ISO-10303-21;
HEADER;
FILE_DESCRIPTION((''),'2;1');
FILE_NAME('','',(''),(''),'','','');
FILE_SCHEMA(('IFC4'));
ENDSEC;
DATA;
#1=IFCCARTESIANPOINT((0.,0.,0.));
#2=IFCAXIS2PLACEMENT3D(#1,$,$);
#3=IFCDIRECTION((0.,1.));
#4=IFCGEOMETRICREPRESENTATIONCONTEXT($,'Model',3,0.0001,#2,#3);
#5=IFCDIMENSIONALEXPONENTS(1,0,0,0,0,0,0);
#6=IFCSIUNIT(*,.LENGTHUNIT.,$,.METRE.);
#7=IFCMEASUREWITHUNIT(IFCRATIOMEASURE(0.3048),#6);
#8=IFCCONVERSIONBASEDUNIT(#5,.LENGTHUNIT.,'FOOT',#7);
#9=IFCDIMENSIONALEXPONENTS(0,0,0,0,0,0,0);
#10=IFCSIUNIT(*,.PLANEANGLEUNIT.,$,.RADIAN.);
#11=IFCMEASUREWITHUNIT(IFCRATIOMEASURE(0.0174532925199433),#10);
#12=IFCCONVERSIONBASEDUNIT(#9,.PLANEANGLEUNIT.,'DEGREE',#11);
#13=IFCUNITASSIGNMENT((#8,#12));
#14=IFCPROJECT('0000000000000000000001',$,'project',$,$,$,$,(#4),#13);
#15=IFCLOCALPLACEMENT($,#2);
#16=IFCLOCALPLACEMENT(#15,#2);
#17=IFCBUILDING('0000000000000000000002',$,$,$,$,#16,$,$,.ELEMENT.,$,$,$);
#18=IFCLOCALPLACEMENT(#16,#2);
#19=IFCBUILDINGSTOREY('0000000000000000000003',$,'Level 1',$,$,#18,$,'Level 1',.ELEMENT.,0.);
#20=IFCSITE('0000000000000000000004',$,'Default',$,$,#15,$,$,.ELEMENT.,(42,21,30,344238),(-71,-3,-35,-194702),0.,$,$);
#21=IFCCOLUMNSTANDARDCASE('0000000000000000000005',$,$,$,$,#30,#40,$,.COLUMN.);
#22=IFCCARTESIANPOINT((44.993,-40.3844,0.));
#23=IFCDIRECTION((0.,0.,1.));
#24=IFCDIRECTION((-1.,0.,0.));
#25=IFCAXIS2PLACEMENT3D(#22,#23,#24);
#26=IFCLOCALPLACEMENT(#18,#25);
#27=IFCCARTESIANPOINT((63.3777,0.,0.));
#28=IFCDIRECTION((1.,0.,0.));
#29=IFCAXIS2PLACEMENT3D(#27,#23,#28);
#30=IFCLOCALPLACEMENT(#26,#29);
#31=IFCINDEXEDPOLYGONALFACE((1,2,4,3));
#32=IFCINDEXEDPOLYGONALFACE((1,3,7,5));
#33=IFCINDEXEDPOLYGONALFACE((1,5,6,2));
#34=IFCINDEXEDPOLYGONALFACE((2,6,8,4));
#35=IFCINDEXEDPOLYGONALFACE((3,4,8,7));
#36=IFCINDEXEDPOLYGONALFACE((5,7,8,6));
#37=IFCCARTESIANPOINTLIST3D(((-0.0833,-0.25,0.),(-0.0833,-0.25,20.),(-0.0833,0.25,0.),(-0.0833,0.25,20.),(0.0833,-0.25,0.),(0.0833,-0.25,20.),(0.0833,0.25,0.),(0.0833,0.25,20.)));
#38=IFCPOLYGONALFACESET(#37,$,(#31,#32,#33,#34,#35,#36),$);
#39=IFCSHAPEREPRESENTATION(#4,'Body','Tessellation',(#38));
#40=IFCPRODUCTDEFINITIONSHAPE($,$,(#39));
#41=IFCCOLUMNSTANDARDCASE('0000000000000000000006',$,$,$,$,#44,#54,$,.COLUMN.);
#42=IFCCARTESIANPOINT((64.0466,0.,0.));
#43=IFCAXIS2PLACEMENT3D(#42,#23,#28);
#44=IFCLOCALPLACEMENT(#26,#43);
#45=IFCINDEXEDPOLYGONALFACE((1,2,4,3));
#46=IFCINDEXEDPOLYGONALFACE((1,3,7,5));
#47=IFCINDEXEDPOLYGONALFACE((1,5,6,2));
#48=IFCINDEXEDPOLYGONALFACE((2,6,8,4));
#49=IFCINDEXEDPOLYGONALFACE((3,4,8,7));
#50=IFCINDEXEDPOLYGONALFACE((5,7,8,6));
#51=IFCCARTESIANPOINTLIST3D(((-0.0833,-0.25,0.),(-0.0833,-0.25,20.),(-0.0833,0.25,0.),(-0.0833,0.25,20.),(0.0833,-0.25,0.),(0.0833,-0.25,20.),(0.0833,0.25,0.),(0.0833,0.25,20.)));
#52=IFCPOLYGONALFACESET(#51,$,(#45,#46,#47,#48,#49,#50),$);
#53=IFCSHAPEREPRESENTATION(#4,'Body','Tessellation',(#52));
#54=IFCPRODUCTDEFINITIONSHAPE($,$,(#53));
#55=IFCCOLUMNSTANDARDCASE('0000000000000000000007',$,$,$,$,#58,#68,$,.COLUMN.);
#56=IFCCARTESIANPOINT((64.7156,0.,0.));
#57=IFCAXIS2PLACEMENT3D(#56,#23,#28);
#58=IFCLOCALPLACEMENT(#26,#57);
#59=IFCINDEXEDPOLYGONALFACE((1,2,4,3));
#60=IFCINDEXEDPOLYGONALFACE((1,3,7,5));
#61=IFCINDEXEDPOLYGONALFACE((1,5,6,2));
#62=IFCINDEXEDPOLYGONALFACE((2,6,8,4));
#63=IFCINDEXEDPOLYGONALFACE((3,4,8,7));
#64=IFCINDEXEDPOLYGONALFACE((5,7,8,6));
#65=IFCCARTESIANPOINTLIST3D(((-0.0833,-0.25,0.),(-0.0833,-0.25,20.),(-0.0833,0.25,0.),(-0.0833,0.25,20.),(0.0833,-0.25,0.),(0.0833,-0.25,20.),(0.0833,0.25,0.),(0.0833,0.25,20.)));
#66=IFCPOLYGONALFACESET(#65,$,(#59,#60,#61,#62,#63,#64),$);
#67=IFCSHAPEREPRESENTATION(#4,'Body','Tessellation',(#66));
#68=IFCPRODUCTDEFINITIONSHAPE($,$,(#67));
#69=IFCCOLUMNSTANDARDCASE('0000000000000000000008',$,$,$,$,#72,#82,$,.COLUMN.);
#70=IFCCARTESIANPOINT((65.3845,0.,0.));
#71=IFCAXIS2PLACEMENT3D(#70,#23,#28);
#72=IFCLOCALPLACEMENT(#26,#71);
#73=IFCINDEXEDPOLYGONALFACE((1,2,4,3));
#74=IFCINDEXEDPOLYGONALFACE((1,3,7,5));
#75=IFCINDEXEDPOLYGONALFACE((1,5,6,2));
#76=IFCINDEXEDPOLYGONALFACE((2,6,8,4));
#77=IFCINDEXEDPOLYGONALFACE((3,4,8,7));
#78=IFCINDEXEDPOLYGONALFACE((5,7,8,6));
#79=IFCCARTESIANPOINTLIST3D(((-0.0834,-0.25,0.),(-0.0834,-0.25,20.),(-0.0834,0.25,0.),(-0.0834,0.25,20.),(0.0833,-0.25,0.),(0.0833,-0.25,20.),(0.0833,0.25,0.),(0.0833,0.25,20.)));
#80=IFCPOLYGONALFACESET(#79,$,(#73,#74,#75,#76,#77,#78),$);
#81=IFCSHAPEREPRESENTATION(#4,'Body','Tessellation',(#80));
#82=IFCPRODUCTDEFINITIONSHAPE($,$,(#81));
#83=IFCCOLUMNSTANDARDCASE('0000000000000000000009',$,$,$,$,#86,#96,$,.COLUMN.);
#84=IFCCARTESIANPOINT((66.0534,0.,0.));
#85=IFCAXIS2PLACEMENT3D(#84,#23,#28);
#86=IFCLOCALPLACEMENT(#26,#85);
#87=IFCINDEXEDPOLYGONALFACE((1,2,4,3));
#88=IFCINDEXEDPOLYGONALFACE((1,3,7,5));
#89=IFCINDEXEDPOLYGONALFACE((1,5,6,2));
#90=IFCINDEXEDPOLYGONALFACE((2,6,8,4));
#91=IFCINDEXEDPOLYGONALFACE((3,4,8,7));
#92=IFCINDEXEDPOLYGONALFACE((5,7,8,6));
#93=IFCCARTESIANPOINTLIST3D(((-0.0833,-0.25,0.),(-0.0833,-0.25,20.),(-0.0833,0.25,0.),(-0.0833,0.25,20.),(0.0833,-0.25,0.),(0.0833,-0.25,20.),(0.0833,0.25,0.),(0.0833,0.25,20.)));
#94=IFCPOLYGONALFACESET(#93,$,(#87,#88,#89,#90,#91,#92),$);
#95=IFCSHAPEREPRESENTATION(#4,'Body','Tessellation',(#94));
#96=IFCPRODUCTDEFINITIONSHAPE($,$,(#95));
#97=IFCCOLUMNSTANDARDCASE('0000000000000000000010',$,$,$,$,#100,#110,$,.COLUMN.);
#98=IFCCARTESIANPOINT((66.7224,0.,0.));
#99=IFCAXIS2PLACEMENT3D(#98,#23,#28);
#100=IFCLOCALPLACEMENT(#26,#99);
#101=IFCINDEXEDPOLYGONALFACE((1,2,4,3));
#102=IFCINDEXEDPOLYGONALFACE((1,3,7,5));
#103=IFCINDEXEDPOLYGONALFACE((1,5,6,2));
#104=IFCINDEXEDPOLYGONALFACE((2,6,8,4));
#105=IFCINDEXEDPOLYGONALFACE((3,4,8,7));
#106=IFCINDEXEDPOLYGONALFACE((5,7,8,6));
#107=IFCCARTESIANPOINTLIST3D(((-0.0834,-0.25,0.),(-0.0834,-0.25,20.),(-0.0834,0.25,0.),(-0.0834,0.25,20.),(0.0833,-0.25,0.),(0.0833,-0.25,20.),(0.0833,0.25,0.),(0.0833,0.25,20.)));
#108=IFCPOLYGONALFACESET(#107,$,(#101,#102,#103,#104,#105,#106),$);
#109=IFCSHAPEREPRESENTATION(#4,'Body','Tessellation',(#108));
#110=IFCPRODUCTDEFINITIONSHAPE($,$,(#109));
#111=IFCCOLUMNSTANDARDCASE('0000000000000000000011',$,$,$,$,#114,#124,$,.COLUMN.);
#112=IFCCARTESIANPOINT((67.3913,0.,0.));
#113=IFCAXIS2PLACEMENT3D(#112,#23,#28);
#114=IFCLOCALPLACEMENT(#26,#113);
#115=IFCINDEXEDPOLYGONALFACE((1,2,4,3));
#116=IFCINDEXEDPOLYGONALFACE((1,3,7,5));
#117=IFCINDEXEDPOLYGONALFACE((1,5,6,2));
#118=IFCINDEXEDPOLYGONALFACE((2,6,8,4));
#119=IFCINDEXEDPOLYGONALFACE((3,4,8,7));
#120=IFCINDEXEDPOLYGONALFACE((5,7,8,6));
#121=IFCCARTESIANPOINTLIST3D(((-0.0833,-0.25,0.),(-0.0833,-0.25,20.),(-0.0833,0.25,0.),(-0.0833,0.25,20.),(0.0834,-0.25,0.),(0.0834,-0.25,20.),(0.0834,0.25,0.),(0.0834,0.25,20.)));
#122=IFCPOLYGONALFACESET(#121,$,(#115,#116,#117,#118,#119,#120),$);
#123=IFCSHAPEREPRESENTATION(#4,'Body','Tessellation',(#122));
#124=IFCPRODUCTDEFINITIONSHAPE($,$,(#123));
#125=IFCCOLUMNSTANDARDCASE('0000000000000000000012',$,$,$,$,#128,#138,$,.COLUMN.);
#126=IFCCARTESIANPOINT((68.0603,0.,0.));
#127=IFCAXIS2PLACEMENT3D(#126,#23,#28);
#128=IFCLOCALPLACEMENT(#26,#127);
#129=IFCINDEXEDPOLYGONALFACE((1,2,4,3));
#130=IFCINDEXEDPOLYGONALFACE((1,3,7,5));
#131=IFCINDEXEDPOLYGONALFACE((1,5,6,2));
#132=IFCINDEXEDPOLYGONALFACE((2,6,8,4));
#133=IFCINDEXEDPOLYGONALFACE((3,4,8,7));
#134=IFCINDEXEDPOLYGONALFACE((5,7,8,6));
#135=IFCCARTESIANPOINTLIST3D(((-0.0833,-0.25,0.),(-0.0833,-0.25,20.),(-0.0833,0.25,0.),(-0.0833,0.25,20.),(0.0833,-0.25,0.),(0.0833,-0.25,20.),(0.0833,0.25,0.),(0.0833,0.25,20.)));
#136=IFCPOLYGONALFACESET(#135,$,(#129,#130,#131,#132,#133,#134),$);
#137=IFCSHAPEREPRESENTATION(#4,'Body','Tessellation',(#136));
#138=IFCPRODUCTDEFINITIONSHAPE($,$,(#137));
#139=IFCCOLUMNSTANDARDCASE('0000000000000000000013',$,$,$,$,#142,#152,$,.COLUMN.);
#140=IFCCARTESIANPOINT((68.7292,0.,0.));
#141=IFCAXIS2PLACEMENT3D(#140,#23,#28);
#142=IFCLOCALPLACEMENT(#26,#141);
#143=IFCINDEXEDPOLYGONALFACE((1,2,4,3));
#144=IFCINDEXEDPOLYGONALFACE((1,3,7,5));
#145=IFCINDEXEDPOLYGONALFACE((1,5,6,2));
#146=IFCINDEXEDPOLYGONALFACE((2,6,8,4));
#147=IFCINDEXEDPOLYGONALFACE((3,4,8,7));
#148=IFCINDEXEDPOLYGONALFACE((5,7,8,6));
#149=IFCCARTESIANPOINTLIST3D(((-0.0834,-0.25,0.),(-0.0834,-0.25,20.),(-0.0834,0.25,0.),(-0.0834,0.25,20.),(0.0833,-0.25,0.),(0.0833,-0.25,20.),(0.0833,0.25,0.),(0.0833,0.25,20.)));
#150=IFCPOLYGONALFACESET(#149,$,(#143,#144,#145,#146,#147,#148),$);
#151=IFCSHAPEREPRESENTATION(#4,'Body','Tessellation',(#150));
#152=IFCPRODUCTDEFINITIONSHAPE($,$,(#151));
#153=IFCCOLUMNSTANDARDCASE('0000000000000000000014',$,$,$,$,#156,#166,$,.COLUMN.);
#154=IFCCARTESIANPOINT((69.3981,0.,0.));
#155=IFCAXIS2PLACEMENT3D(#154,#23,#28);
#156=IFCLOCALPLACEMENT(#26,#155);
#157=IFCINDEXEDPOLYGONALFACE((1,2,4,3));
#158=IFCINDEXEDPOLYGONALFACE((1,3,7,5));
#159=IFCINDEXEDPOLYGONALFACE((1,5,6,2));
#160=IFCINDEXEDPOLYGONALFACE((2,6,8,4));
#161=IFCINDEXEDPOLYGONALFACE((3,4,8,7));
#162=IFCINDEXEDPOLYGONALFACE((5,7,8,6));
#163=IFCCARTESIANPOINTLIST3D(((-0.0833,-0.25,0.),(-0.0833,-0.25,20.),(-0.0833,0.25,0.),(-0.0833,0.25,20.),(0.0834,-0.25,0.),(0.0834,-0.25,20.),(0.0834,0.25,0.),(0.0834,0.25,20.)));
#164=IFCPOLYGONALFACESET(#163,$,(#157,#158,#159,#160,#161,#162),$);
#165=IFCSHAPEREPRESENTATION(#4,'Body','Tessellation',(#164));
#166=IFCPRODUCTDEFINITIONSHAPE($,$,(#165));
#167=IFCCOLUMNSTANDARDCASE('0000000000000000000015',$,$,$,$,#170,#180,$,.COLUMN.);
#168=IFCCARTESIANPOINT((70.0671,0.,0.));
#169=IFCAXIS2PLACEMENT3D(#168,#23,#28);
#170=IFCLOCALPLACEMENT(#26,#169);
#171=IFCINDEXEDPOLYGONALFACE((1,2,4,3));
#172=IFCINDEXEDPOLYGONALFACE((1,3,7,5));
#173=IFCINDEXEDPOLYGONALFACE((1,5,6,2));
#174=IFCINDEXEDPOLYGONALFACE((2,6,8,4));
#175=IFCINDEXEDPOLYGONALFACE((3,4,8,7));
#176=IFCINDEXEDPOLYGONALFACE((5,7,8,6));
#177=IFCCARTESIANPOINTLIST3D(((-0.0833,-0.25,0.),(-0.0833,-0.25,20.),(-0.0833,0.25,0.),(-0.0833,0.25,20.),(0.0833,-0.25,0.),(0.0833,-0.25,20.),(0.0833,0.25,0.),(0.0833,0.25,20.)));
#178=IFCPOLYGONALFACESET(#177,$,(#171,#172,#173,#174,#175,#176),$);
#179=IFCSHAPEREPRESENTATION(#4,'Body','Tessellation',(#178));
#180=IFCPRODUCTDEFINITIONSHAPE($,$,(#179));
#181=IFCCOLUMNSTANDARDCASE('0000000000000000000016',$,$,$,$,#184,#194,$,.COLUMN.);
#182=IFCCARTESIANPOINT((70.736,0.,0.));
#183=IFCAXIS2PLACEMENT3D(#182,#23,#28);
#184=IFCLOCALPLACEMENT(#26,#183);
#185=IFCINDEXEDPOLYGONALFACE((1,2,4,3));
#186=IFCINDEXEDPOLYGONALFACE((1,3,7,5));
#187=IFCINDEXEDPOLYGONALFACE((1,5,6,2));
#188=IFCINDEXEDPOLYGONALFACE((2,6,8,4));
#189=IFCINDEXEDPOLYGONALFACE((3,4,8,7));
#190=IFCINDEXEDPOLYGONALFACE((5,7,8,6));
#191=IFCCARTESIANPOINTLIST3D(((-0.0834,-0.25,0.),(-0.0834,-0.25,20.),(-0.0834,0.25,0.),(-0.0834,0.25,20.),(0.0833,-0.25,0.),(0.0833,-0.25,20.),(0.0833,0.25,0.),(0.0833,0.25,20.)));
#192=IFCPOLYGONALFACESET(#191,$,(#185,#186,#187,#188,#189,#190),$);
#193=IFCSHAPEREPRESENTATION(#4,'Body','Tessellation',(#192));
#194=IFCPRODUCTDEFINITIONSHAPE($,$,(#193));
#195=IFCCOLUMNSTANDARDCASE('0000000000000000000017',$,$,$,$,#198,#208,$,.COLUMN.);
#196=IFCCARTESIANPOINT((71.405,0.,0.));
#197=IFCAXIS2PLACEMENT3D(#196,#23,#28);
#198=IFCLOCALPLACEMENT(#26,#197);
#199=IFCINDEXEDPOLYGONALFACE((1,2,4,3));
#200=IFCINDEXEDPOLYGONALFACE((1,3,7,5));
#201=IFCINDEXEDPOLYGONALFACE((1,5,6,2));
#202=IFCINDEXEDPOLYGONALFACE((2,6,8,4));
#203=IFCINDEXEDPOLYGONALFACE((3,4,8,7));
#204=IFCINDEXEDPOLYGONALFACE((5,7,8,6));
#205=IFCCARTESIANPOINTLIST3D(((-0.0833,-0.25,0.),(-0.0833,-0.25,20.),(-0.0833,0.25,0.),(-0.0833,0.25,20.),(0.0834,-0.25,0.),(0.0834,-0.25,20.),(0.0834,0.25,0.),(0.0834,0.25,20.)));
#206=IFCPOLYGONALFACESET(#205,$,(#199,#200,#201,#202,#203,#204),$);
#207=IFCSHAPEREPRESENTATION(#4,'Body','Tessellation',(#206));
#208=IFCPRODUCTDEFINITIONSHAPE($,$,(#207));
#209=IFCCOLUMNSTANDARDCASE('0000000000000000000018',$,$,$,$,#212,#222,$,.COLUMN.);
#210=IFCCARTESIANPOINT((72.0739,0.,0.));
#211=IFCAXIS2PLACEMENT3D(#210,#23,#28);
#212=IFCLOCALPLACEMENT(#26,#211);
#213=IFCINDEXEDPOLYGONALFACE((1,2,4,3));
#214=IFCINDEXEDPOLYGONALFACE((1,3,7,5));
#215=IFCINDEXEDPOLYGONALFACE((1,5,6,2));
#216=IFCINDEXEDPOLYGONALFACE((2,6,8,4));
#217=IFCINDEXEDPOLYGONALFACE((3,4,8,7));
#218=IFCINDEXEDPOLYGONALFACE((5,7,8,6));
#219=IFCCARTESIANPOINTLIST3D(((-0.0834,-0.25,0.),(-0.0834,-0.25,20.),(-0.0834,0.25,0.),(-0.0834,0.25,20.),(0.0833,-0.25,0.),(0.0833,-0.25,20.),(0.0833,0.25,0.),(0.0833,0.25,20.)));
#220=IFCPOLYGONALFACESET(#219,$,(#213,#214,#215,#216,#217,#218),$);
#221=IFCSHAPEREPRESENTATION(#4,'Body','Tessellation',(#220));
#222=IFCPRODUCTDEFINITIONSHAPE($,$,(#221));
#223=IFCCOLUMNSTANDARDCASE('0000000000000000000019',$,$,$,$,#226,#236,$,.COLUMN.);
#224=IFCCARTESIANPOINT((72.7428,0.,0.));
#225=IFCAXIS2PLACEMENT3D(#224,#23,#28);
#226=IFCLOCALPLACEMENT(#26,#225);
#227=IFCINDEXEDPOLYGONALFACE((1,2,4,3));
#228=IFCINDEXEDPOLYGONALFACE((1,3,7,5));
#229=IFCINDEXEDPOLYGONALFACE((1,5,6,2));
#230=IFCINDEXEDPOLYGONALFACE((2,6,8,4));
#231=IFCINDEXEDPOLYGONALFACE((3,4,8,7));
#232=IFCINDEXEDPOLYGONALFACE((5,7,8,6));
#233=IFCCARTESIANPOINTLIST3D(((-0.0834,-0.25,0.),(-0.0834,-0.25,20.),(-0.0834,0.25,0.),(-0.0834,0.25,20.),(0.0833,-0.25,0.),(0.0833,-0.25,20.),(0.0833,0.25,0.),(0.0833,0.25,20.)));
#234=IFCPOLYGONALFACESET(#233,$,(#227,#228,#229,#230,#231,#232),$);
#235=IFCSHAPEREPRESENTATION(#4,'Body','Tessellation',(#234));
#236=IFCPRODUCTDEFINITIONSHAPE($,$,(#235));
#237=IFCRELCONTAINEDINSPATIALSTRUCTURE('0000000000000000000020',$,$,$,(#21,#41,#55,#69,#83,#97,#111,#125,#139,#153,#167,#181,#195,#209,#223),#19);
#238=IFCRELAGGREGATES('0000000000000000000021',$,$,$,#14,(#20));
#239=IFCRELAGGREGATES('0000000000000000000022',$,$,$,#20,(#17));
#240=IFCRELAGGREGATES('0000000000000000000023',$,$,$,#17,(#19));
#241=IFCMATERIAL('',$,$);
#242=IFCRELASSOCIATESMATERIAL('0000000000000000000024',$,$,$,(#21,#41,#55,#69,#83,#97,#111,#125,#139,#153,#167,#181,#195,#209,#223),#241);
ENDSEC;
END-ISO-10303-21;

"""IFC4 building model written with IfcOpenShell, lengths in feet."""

from ifc_helpers import new_model, entity, si_unit, converted_unit, direction, frame, origin, place, context, project, spatial, rectangle, extrude, material, element, save


model = new_model("IFC4")

# Units and contexts
model_context = context("Model", 3, precision=0.0001, world=origin(), true_north=direction((0.0, 1.0)))
ifc_project = project(units=[converted_unit("LENGTHUNIT", "FOOT", entity("IfcRatioMeasure", 0.3048), si_unit("LENGTHUNIT", "METRE"), dimensions=[1, 0, 0, 0, 0, 0, 0]), converted_unit("PLANEANGLEUNIT", "DEGREE", entity("IfcRatioMeasure", 0.0174532925199433), si_unit("PLANEANGLEUNIT", "RADIAN"), dimensions=[0, 0, 0, 0, 0, 0, 0])], contexts=[model_context])

# Site, building, storey
site_placement = place(None, origin())
site = spatial("IfcSite", under=ifc_project, at=site_placement, Name="Default", CompositionType="ELEMENT", RefLatitude=(42, 21, 30, 344238), RefLongitude=(-71, -3, -35, -194702), RefElevation=0.0)
building_placement = place(site_placement, origin())
building = spatial("IfcBuilding", under=site, at=building_placement, CompositionType="ELEMENT")
storey_placement = place(building_placement, origin())
storey = spatial("IfcBuildingStorey", under=building, at=storey_placement, Name="Level 1", LongName="Level 1", CompositionType="ELEMENT", Elevation=0.0)

# Columns
ifc_material_1 = material(Name="")
placement = place(storey_placement, frame((44.993, -40.3844, 0.0), z_axis=(0.0, 0.0, 1.0), x_axis=(-1.0, 0.0, 0.0)))
for number, where, z_axis, x_axis in (
    (1, (63.3777, 0.0, 0.0), (0.0, 0.0, 1.0), (1.0, 0.0, 0.0)),
    (2, (64.0466, 0.0, 0.0), (0.0, 0.0, 1.0), (1.0, 0.0, 0.0)),
    (3, (64.7156, 0.0, 0.0), (0.0, 0.0, 1.0), (1.0, 0.0, 0.0)),
    (4, (65.3845, 0.0, 0.0), (0.0, 0.0, 1.0), (1.0, 0.0, 0.0)),
    (5, (66.0534, 0.0, 0.0), (0.0, 0.0, 1.0), (1.0, 0.0, 0.0)),
    (6, (66.7224, 0.0, 0.0), (0.0, 0.0, 1.0), (1.0, 0.0, 0.0)),
    (7, (67.3913, 0.0, 0.0), (0.0, 0.0, 1.0), (1.0, 0.0, 0.0)),
    (8, (68.0603, 0.0, 0.0), (0.0, 0.0, 1.0), (1.0, 0.0, 0.0)),
    (9, (68.7292, 0.0, 0.0), (0.0, 0.0, 1.0), (1.0, 0.0, 0.0)),
    (10, (69.3981, 0.0, 0.0), (0.0, 0.0, 1.0), (1.0, 0.0, 0.0)),
    (11, (70.0671, 0.0, 0.0), (0.0, 0.0, 1.0), (1.0, 0.0, 0.0)),
    (12, (70.736, 0.0, 0.0), (0.0, 0.0, 1.0), (1.0, 0.0, 0.0)),
    (13, (71.405, 0.0, 0.0), (0.0, 0.0, 1.0), (1.0, 0.0, 0.0)),
    (14, (72.0739, 0.0, 0.0), (0.0, 0.0, 1.0), (1.0, 0.0, 0.0)),
    (15, (72.7428, 0.0, 0.0), (0.0, 0.0, 1.0), (1.0, 0.0, 0.0)),
):
    element("IfcColumnStandardCase", number, at=place(placement, frame(where, z_axis=z_axis, x_axis=x_axis)), inside=storey, material=ifc_material_1, PredefinedType="COLUMN", context=model_context, shape_type="SweptSolid", body=[
        extrude(rectangle(XDim=0.1667, YDim=0.5), origin(), (0.0, 0.0, 1.0), 20.0),
    ])

save(model, "model.ifc")
